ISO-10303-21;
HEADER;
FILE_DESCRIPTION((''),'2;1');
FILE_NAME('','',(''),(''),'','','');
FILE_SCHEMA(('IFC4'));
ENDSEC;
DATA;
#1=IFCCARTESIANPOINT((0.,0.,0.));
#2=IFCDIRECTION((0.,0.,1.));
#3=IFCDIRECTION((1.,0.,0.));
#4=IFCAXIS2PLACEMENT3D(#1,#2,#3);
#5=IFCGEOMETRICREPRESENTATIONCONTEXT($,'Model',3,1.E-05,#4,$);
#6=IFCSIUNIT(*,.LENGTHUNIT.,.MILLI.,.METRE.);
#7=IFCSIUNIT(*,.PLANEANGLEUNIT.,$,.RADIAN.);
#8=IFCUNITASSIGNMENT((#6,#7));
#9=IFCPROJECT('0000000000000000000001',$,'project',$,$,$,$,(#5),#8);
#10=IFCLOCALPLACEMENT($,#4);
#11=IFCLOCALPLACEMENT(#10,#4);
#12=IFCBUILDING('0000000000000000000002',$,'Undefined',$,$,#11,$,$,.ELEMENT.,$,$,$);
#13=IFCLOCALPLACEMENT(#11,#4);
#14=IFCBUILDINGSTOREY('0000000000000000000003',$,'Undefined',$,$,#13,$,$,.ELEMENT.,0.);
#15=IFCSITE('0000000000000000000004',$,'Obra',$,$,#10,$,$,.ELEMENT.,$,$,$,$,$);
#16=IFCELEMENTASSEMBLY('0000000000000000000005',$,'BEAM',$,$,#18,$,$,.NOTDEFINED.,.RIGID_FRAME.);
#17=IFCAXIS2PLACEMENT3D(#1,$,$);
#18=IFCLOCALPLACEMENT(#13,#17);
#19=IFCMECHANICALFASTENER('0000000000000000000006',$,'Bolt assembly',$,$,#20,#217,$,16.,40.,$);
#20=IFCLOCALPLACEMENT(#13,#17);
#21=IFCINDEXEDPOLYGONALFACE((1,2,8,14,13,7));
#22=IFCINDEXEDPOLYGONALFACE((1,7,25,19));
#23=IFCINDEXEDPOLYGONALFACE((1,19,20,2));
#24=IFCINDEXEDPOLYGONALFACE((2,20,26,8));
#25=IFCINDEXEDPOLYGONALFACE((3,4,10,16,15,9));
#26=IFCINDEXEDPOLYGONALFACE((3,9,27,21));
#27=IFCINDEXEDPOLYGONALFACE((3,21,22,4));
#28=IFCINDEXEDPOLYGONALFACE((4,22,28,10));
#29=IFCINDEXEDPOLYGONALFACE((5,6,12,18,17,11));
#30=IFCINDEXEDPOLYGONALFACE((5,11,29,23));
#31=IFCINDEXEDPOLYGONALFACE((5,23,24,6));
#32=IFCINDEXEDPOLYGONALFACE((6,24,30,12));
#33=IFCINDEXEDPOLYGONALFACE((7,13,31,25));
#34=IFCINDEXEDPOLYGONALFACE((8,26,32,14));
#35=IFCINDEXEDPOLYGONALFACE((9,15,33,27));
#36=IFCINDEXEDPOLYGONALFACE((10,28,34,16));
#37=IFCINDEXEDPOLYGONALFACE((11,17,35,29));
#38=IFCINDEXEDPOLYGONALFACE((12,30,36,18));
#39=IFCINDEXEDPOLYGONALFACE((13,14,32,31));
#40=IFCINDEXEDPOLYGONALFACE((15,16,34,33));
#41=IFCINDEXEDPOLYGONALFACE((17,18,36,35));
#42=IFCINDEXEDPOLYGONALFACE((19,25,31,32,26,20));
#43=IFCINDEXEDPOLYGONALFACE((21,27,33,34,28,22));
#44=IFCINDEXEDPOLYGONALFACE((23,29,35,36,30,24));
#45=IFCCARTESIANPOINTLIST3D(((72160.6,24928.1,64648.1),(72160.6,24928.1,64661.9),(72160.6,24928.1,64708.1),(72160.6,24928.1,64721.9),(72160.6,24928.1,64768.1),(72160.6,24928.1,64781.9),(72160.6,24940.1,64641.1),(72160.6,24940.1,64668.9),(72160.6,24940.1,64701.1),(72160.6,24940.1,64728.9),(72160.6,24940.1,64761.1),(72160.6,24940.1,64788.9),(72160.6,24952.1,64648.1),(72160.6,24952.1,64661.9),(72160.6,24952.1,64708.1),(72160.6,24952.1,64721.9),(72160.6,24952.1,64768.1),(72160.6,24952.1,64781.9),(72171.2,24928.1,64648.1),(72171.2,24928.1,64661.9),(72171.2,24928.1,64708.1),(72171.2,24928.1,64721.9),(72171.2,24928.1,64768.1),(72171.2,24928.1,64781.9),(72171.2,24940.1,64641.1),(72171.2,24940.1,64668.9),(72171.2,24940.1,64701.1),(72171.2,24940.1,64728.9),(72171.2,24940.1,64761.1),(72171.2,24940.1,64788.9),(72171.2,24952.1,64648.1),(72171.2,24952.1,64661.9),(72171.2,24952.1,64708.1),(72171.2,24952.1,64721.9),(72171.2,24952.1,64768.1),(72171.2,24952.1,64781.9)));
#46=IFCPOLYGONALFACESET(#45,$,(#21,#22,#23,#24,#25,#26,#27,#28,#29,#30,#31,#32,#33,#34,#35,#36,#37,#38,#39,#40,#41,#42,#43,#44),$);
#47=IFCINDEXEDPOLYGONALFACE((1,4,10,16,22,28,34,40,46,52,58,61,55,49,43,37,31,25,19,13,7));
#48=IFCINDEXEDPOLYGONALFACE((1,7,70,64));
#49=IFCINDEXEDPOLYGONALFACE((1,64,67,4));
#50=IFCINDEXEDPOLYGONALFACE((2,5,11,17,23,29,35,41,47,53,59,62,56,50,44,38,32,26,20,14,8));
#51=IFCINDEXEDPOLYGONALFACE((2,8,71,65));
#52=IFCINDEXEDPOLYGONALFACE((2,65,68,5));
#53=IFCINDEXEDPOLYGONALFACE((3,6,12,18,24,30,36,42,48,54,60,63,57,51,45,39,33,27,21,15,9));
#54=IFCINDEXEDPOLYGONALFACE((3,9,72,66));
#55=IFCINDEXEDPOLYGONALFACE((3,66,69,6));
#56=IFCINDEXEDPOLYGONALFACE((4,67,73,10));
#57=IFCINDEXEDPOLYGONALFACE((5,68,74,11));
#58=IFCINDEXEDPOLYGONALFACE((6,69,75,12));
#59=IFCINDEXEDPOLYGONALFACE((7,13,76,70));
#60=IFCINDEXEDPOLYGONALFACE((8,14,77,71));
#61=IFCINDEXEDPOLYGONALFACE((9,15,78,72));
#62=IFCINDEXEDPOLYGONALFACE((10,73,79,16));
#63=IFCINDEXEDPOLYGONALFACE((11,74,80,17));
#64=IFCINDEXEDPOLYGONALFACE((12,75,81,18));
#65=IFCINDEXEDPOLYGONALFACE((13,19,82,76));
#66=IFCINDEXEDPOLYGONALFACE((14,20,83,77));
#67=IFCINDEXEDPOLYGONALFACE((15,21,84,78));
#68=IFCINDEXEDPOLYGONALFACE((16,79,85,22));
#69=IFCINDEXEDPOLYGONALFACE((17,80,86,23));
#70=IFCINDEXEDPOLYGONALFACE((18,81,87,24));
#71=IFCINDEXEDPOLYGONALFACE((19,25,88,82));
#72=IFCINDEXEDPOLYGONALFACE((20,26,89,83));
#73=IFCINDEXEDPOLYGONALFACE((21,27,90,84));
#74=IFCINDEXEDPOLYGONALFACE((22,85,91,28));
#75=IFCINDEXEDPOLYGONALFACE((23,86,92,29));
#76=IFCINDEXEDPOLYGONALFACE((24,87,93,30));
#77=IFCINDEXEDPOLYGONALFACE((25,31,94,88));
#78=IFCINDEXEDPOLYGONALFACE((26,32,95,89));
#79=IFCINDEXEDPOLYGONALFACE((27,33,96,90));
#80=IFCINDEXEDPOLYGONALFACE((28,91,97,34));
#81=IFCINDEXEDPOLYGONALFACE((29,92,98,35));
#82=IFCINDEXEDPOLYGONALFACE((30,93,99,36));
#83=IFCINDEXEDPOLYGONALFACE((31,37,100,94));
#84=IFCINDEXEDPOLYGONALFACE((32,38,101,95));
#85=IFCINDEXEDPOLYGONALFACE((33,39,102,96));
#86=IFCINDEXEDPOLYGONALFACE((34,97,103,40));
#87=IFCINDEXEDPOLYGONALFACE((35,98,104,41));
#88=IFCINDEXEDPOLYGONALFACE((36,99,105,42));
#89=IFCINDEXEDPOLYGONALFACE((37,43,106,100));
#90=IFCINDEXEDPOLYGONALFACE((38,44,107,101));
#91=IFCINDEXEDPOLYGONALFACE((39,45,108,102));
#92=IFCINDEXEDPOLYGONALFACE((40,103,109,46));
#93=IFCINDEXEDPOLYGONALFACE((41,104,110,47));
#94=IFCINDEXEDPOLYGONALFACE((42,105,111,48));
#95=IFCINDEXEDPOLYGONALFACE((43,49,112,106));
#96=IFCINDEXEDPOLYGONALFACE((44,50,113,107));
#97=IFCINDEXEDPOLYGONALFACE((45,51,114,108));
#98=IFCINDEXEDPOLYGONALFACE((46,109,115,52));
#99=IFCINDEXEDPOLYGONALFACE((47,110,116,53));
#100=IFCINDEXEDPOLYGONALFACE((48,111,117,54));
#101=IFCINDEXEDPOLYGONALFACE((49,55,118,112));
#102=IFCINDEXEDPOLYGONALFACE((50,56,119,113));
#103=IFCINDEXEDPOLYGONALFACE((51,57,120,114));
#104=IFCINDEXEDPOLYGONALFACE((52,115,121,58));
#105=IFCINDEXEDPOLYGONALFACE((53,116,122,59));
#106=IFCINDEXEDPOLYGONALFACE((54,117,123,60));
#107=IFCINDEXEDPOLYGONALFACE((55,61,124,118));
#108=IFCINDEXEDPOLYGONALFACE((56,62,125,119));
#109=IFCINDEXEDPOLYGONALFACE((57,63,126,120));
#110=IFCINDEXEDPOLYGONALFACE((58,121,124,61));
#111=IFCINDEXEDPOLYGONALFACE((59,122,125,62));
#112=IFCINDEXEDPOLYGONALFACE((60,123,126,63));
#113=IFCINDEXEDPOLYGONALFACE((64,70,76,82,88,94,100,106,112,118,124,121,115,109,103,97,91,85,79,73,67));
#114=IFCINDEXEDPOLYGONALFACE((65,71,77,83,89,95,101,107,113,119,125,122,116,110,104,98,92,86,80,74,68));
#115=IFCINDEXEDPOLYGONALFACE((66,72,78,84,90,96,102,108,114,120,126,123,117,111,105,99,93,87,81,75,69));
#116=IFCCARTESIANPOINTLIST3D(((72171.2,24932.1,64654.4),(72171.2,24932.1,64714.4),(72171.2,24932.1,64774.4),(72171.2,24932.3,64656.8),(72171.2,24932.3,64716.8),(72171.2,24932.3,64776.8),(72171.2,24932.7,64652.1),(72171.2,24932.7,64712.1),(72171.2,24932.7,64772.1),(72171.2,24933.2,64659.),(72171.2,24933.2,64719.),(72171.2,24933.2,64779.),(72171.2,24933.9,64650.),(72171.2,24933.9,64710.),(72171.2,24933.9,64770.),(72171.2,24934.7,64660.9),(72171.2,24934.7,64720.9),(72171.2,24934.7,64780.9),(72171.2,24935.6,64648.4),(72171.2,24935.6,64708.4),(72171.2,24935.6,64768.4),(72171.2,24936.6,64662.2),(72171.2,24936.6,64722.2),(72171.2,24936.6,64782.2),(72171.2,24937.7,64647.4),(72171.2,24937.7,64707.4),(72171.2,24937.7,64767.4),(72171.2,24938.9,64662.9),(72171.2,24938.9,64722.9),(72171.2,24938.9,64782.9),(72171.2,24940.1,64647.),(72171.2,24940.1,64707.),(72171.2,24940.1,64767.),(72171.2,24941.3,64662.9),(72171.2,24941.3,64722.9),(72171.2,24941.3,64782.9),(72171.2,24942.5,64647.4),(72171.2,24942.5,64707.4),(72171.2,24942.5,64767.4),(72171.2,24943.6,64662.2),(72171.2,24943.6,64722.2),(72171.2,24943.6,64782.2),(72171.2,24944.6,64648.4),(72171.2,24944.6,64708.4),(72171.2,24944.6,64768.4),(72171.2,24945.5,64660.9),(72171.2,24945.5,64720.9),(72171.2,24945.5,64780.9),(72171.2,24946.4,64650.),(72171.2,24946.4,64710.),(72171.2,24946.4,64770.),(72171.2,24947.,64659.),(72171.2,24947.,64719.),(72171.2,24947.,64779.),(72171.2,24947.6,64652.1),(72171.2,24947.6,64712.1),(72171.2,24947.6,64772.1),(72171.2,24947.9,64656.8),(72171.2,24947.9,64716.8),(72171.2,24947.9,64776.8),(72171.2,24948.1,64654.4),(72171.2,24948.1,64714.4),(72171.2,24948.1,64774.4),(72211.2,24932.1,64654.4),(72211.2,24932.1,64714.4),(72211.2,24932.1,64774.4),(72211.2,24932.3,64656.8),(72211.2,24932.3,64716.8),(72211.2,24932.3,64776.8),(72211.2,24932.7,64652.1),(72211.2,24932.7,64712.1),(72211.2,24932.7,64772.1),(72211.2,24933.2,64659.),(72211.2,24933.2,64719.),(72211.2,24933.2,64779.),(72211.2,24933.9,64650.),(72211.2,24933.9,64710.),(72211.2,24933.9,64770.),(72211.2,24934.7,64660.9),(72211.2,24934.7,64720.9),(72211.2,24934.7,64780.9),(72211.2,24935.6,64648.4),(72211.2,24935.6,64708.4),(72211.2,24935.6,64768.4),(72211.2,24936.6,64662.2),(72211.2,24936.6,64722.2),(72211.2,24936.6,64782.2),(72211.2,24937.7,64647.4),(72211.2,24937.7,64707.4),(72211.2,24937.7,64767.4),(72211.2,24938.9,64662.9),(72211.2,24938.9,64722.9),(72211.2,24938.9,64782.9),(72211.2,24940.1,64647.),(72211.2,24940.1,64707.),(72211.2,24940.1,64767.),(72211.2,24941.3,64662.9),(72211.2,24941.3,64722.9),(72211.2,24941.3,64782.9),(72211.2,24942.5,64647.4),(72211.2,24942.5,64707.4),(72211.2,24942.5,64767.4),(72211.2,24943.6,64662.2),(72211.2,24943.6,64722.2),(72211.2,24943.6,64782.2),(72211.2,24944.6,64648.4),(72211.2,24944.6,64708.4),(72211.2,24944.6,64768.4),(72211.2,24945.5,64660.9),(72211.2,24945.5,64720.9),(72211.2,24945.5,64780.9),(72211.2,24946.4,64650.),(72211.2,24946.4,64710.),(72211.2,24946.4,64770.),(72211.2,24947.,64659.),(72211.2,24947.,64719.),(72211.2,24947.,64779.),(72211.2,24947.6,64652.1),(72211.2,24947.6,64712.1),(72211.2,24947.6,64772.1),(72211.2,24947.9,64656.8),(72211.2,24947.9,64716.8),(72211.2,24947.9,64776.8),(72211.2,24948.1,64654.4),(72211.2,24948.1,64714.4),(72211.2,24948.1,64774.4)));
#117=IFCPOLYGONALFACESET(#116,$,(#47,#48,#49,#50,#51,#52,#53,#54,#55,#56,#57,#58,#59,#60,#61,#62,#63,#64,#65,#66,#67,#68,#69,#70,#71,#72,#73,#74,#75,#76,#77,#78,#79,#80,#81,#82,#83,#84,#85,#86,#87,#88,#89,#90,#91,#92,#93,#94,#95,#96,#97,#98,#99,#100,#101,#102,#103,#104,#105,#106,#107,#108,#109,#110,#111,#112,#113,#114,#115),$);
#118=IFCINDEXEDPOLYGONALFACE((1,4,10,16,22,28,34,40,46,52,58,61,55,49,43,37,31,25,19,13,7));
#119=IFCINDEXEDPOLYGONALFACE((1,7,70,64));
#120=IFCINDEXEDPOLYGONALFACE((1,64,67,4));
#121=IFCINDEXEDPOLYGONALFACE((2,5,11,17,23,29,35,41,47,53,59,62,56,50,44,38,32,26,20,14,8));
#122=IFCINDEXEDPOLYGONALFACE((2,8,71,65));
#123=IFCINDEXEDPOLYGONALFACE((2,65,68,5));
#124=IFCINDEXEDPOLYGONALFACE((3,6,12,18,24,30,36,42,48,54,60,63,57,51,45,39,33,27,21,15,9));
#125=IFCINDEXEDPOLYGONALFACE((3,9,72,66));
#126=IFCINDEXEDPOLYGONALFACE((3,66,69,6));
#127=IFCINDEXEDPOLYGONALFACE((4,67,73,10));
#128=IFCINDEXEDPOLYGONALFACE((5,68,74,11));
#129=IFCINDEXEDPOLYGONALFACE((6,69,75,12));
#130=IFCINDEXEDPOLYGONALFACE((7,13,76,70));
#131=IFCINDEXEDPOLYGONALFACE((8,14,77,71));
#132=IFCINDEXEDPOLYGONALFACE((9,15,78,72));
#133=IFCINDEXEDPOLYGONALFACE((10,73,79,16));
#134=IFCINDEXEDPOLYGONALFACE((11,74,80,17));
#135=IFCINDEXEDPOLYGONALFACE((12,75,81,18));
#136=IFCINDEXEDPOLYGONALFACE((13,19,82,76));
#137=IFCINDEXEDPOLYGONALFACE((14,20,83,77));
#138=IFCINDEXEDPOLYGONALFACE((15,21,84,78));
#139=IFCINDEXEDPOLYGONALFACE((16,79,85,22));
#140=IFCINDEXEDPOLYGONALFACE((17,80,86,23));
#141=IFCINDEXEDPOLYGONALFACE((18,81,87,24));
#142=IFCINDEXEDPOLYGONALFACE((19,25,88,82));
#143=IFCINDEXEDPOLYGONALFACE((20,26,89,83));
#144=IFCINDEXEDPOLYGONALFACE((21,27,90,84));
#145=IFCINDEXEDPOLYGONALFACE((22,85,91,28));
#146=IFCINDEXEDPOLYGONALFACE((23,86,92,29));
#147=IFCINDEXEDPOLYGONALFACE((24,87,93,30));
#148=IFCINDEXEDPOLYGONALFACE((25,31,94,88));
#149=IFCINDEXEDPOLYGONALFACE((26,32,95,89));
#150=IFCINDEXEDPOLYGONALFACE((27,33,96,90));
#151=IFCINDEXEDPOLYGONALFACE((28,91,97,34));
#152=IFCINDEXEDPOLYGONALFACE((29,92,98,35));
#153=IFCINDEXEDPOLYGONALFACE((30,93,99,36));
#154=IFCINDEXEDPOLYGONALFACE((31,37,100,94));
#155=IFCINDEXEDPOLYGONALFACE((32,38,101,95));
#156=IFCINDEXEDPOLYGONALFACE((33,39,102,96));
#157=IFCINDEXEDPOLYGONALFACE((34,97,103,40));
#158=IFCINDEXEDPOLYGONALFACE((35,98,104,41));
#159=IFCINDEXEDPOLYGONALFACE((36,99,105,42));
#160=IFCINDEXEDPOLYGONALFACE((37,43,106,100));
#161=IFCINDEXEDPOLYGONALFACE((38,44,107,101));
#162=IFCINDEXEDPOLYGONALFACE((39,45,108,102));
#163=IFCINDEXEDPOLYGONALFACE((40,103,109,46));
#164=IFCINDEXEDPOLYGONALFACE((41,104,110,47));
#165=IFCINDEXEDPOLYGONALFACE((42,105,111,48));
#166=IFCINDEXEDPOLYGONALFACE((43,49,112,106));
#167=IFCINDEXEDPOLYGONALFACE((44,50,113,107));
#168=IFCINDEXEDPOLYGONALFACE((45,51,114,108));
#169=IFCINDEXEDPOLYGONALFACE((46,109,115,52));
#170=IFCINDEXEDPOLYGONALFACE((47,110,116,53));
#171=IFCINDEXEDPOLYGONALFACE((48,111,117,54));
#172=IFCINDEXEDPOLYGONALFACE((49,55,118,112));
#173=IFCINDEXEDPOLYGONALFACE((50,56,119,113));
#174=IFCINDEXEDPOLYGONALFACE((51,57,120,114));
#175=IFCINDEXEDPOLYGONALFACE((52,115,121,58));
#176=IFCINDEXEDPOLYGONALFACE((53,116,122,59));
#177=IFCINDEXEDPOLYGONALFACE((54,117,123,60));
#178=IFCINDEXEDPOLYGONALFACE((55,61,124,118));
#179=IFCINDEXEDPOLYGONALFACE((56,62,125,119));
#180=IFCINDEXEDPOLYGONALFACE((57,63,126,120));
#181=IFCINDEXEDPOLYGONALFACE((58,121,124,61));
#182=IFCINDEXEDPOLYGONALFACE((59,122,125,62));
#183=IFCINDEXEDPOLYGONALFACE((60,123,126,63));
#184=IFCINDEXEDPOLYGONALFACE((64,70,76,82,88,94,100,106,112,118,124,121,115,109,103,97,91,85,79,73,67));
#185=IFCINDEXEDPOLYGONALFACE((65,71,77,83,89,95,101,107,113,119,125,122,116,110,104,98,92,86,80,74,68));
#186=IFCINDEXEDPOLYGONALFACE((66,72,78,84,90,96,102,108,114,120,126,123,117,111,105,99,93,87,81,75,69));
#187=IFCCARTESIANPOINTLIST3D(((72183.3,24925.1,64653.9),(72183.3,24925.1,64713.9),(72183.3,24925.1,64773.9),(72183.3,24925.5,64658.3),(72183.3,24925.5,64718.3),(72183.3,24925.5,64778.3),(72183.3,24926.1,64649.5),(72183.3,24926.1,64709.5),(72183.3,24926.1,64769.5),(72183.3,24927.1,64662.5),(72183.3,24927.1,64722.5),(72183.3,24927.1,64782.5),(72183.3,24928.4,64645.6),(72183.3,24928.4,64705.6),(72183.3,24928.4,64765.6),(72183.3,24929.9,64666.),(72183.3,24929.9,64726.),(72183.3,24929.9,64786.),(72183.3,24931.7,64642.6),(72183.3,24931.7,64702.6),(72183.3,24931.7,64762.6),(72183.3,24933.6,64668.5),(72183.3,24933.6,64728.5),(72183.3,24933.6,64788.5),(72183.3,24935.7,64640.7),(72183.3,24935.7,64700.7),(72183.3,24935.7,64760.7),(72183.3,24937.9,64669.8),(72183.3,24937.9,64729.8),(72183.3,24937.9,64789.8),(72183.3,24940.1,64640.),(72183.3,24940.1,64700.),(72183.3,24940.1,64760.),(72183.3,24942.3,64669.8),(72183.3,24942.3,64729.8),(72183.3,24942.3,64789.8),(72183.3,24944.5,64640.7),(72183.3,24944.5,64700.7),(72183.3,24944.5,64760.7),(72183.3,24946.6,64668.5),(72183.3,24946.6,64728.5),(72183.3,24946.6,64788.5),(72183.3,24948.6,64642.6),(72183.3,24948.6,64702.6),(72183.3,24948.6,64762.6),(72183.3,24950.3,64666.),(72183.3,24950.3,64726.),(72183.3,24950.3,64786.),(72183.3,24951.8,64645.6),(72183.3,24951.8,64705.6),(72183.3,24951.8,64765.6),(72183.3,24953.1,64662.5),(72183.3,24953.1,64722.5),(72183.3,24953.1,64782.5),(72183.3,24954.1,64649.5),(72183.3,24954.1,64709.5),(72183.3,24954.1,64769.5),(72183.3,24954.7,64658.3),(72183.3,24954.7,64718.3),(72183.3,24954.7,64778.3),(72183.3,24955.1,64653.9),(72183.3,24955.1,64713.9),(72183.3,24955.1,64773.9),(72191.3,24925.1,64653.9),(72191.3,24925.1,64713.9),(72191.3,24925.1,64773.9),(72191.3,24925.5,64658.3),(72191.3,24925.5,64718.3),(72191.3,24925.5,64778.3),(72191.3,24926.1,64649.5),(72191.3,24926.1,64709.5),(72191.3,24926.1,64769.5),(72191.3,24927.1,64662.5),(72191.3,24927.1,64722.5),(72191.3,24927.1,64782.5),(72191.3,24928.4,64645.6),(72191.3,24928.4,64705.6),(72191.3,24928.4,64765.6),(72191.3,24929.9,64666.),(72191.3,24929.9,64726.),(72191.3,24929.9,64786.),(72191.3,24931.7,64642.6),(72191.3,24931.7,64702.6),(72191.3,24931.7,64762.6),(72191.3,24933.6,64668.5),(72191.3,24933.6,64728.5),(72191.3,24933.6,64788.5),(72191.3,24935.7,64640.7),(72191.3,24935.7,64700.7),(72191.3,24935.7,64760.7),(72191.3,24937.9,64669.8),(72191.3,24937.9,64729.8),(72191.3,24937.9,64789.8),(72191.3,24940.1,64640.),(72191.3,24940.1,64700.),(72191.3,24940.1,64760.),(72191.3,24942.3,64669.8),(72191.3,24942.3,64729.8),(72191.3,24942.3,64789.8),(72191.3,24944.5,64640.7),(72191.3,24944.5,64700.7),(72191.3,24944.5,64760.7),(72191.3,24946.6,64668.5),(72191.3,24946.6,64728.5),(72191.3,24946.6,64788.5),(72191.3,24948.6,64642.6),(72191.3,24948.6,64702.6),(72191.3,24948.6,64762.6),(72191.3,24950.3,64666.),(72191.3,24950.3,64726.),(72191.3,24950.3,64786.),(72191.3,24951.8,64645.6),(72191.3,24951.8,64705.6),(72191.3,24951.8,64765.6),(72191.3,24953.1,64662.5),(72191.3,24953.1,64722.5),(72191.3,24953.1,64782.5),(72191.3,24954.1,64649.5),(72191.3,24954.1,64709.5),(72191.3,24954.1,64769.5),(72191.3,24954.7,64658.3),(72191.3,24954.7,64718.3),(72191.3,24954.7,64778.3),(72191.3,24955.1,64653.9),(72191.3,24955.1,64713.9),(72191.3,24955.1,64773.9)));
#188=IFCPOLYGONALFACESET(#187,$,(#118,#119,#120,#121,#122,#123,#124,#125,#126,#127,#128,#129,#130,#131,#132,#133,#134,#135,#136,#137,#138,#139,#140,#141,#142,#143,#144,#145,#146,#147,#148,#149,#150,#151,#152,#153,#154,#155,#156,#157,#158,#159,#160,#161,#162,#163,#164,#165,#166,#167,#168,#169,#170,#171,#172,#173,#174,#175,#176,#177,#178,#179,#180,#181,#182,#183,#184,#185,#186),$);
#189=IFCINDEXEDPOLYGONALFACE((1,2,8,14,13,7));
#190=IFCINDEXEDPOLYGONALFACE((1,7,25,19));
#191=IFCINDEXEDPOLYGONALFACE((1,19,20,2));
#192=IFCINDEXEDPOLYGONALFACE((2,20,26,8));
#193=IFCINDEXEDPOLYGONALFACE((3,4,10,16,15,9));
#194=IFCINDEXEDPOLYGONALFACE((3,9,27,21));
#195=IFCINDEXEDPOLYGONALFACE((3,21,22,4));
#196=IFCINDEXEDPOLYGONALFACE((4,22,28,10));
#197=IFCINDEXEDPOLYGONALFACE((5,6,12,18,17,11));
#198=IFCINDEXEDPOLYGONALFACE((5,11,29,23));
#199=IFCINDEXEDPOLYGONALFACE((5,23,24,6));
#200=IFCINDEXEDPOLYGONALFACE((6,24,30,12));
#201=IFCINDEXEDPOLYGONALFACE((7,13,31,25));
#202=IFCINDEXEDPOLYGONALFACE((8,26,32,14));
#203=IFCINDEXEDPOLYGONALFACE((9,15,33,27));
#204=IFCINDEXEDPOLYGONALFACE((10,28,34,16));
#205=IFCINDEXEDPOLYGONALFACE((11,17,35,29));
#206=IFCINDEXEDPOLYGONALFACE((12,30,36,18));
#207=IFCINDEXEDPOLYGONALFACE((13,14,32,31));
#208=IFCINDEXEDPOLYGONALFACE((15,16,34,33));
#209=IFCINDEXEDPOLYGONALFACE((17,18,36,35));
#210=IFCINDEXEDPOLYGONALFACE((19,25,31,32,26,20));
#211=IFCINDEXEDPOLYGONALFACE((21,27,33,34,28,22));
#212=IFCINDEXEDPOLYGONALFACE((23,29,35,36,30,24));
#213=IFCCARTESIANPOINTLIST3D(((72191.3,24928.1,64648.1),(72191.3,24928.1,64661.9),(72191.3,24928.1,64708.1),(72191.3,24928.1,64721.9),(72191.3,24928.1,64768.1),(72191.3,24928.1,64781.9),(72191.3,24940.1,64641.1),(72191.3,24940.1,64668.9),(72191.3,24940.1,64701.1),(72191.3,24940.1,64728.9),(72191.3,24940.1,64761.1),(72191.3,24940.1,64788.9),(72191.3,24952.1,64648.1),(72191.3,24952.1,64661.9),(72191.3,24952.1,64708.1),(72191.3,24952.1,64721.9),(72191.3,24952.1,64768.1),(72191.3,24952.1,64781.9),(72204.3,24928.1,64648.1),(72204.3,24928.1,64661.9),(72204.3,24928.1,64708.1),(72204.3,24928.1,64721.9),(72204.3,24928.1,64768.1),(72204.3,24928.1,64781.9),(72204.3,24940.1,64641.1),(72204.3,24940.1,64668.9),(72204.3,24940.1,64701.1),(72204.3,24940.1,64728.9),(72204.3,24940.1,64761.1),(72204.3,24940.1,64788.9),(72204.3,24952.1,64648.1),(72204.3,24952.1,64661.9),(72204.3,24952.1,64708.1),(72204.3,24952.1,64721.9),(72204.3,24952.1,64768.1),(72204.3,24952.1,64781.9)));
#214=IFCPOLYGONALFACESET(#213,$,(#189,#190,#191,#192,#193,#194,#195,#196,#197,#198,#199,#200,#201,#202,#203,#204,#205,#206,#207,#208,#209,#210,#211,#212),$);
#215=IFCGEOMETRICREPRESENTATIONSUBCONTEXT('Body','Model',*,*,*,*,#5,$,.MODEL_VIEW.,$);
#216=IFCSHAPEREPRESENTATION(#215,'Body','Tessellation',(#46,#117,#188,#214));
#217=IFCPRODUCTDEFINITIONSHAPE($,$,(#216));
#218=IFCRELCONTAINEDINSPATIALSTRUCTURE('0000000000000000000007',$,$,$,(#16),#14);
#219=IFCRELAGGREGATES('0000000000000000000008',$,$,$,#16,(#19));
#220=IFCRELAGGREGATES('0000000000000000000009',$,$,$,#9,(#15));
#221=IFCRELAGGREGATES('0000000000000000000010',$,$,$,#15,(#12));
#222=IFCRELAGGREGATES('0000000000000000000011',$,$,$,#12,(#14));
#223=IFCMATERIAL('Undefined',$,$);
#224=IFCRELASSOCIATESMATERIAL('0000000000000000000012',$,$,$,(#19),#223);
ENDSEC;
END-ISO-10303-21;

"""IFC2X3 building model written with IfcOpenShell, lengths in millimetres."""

from ifc_helpers import new_model, si_unit, frame, origin_with_axes, origin_2d_with_axis, place, context, subcontext, project, spatial, polyline, circle, outline, extrude, source, transform, mapped, material, element, aggregate, save


model = new_model("IFC2X3")

# Units and contexts
model_context = context("Model", 3, precision=1e-05, world=origin_with_axes())
body_context = subcontext(model_context, "Body", "Model", "MODEL_VIEW")
ifc_project = project(units=[si_unit("LENGTHUNIT", "METRE", prefix="MILLI"), si_unit("PLANEANGLEUNIT", "RADIAN")], contexts=[model_context])

# Site, building, storey
site_placement = place(None, origin_with_axes())
site = spatial("IfcSite", under=ifc_project, at=site_placement, Name="Obra", CompositionType="ELEMENT")
building_placement = place(site_placement, origin_with_axes())
building = spatial("IfcBuilding", under=site, at=building_placement, Name="Undefined", CompositionType="ELEMENT")
storey_placement = place(building_placement, origin_with_axes())
storey = spatial("IfcBuildingStorey", under=building, at=storey_placement, Name="Undefined", CompositionType="ELEMENT", Elevation=0.0)

# Element assembly
ifc_material_1 = material(Name="Undefined")
assembly_1_placement = place(storey_placement, origin_with_axes())
assembly_1 = element("IfcElementAssembly", 1, at=assembly_1_placement, inside=storey, Name="BEAM", AssemblyPlace="NOTDEFINED", PredefinedType="RIGID_FRAME")

# Mechanical fastener
shared_shape_1 = source(origin_with_axes(), body_context, "Body", "SweptSolid", [
    extrude(outline(polyline([(13.9, 0.0), (6.9, 12.0), (-6.9, 12.0), (-13.9, 0.0), (-6.9, -12.0), (6.9, -12.0), (13.9, 0.0)])), frame((0.0, -19.7, 0.0), z_axis=(0.0, 1.0, 0.0), x_axis=(1.0, 0.0, 0.0)), (0.0, 0.0, 1.0), 10.6),
    extrude(circle(Radius=8.0, at=origin_2d_with_axis()), frame((0.0, -9.1, 0.0), z_axis=(0.0, 1.0, 0.0), x_axis=(1.0, 0.0, 0.0)), (0.0, 0.0, 1.0), 40.0),
    extrude(circle(Radius=15.0, at=origin_2d_with_axis()), frame((0.0, 3.0, 0.0), z_axis=(0.0, 1.0, 0.0), x_axis=(1.0, 0.0, 0.0)), (0.0, 0.0, 1.0), 8.0),
    extrude(outline(polyline([(13.9, 0.0), (6.9, 12.0), (-6.9, 12.0), (-13.9, 0.0), (-6.9, -12.0), (6.9, -12.0), (13.9, 0.0)])), frame((0.0, 11.0, 0.0), z_axis=(0.0, 1.0, 0.0), x_axis=(1.0, 0.0, 0.0)), (0.0, 0.0, 1.0), 13.0),
])
mechanical_fastener_1_placement = place(assembly_1_placement, frame((72180.3, 24990.1, 64835.0), z_axis=(0.000002, -1.0, 0.0), x_axis=(0.0, 0.0, -1.0)))
mechanical_fastener_1 = element("IfcMechanicalFastener", 2, at=mechanical_fastener_1_placement, material=ifc_material_1, Name="Bolt assembly", NominalDiameter=16.0, NominalLength=40.0, context=body_context, shape_type="MappedRepresentation", body=[
    mapped(shared_shape_1, transform((60.0, 0.0, 50.0))),
    mapped(shared_shape_1, transform((120.0, 0.0, 50.0))),
    mapped(shared_shape_1, transform((180.0, 0.0, 50.0))),
])
aggregate(assembly_1, [mechanical_fastener_1])

save(model, "model.ifc")
